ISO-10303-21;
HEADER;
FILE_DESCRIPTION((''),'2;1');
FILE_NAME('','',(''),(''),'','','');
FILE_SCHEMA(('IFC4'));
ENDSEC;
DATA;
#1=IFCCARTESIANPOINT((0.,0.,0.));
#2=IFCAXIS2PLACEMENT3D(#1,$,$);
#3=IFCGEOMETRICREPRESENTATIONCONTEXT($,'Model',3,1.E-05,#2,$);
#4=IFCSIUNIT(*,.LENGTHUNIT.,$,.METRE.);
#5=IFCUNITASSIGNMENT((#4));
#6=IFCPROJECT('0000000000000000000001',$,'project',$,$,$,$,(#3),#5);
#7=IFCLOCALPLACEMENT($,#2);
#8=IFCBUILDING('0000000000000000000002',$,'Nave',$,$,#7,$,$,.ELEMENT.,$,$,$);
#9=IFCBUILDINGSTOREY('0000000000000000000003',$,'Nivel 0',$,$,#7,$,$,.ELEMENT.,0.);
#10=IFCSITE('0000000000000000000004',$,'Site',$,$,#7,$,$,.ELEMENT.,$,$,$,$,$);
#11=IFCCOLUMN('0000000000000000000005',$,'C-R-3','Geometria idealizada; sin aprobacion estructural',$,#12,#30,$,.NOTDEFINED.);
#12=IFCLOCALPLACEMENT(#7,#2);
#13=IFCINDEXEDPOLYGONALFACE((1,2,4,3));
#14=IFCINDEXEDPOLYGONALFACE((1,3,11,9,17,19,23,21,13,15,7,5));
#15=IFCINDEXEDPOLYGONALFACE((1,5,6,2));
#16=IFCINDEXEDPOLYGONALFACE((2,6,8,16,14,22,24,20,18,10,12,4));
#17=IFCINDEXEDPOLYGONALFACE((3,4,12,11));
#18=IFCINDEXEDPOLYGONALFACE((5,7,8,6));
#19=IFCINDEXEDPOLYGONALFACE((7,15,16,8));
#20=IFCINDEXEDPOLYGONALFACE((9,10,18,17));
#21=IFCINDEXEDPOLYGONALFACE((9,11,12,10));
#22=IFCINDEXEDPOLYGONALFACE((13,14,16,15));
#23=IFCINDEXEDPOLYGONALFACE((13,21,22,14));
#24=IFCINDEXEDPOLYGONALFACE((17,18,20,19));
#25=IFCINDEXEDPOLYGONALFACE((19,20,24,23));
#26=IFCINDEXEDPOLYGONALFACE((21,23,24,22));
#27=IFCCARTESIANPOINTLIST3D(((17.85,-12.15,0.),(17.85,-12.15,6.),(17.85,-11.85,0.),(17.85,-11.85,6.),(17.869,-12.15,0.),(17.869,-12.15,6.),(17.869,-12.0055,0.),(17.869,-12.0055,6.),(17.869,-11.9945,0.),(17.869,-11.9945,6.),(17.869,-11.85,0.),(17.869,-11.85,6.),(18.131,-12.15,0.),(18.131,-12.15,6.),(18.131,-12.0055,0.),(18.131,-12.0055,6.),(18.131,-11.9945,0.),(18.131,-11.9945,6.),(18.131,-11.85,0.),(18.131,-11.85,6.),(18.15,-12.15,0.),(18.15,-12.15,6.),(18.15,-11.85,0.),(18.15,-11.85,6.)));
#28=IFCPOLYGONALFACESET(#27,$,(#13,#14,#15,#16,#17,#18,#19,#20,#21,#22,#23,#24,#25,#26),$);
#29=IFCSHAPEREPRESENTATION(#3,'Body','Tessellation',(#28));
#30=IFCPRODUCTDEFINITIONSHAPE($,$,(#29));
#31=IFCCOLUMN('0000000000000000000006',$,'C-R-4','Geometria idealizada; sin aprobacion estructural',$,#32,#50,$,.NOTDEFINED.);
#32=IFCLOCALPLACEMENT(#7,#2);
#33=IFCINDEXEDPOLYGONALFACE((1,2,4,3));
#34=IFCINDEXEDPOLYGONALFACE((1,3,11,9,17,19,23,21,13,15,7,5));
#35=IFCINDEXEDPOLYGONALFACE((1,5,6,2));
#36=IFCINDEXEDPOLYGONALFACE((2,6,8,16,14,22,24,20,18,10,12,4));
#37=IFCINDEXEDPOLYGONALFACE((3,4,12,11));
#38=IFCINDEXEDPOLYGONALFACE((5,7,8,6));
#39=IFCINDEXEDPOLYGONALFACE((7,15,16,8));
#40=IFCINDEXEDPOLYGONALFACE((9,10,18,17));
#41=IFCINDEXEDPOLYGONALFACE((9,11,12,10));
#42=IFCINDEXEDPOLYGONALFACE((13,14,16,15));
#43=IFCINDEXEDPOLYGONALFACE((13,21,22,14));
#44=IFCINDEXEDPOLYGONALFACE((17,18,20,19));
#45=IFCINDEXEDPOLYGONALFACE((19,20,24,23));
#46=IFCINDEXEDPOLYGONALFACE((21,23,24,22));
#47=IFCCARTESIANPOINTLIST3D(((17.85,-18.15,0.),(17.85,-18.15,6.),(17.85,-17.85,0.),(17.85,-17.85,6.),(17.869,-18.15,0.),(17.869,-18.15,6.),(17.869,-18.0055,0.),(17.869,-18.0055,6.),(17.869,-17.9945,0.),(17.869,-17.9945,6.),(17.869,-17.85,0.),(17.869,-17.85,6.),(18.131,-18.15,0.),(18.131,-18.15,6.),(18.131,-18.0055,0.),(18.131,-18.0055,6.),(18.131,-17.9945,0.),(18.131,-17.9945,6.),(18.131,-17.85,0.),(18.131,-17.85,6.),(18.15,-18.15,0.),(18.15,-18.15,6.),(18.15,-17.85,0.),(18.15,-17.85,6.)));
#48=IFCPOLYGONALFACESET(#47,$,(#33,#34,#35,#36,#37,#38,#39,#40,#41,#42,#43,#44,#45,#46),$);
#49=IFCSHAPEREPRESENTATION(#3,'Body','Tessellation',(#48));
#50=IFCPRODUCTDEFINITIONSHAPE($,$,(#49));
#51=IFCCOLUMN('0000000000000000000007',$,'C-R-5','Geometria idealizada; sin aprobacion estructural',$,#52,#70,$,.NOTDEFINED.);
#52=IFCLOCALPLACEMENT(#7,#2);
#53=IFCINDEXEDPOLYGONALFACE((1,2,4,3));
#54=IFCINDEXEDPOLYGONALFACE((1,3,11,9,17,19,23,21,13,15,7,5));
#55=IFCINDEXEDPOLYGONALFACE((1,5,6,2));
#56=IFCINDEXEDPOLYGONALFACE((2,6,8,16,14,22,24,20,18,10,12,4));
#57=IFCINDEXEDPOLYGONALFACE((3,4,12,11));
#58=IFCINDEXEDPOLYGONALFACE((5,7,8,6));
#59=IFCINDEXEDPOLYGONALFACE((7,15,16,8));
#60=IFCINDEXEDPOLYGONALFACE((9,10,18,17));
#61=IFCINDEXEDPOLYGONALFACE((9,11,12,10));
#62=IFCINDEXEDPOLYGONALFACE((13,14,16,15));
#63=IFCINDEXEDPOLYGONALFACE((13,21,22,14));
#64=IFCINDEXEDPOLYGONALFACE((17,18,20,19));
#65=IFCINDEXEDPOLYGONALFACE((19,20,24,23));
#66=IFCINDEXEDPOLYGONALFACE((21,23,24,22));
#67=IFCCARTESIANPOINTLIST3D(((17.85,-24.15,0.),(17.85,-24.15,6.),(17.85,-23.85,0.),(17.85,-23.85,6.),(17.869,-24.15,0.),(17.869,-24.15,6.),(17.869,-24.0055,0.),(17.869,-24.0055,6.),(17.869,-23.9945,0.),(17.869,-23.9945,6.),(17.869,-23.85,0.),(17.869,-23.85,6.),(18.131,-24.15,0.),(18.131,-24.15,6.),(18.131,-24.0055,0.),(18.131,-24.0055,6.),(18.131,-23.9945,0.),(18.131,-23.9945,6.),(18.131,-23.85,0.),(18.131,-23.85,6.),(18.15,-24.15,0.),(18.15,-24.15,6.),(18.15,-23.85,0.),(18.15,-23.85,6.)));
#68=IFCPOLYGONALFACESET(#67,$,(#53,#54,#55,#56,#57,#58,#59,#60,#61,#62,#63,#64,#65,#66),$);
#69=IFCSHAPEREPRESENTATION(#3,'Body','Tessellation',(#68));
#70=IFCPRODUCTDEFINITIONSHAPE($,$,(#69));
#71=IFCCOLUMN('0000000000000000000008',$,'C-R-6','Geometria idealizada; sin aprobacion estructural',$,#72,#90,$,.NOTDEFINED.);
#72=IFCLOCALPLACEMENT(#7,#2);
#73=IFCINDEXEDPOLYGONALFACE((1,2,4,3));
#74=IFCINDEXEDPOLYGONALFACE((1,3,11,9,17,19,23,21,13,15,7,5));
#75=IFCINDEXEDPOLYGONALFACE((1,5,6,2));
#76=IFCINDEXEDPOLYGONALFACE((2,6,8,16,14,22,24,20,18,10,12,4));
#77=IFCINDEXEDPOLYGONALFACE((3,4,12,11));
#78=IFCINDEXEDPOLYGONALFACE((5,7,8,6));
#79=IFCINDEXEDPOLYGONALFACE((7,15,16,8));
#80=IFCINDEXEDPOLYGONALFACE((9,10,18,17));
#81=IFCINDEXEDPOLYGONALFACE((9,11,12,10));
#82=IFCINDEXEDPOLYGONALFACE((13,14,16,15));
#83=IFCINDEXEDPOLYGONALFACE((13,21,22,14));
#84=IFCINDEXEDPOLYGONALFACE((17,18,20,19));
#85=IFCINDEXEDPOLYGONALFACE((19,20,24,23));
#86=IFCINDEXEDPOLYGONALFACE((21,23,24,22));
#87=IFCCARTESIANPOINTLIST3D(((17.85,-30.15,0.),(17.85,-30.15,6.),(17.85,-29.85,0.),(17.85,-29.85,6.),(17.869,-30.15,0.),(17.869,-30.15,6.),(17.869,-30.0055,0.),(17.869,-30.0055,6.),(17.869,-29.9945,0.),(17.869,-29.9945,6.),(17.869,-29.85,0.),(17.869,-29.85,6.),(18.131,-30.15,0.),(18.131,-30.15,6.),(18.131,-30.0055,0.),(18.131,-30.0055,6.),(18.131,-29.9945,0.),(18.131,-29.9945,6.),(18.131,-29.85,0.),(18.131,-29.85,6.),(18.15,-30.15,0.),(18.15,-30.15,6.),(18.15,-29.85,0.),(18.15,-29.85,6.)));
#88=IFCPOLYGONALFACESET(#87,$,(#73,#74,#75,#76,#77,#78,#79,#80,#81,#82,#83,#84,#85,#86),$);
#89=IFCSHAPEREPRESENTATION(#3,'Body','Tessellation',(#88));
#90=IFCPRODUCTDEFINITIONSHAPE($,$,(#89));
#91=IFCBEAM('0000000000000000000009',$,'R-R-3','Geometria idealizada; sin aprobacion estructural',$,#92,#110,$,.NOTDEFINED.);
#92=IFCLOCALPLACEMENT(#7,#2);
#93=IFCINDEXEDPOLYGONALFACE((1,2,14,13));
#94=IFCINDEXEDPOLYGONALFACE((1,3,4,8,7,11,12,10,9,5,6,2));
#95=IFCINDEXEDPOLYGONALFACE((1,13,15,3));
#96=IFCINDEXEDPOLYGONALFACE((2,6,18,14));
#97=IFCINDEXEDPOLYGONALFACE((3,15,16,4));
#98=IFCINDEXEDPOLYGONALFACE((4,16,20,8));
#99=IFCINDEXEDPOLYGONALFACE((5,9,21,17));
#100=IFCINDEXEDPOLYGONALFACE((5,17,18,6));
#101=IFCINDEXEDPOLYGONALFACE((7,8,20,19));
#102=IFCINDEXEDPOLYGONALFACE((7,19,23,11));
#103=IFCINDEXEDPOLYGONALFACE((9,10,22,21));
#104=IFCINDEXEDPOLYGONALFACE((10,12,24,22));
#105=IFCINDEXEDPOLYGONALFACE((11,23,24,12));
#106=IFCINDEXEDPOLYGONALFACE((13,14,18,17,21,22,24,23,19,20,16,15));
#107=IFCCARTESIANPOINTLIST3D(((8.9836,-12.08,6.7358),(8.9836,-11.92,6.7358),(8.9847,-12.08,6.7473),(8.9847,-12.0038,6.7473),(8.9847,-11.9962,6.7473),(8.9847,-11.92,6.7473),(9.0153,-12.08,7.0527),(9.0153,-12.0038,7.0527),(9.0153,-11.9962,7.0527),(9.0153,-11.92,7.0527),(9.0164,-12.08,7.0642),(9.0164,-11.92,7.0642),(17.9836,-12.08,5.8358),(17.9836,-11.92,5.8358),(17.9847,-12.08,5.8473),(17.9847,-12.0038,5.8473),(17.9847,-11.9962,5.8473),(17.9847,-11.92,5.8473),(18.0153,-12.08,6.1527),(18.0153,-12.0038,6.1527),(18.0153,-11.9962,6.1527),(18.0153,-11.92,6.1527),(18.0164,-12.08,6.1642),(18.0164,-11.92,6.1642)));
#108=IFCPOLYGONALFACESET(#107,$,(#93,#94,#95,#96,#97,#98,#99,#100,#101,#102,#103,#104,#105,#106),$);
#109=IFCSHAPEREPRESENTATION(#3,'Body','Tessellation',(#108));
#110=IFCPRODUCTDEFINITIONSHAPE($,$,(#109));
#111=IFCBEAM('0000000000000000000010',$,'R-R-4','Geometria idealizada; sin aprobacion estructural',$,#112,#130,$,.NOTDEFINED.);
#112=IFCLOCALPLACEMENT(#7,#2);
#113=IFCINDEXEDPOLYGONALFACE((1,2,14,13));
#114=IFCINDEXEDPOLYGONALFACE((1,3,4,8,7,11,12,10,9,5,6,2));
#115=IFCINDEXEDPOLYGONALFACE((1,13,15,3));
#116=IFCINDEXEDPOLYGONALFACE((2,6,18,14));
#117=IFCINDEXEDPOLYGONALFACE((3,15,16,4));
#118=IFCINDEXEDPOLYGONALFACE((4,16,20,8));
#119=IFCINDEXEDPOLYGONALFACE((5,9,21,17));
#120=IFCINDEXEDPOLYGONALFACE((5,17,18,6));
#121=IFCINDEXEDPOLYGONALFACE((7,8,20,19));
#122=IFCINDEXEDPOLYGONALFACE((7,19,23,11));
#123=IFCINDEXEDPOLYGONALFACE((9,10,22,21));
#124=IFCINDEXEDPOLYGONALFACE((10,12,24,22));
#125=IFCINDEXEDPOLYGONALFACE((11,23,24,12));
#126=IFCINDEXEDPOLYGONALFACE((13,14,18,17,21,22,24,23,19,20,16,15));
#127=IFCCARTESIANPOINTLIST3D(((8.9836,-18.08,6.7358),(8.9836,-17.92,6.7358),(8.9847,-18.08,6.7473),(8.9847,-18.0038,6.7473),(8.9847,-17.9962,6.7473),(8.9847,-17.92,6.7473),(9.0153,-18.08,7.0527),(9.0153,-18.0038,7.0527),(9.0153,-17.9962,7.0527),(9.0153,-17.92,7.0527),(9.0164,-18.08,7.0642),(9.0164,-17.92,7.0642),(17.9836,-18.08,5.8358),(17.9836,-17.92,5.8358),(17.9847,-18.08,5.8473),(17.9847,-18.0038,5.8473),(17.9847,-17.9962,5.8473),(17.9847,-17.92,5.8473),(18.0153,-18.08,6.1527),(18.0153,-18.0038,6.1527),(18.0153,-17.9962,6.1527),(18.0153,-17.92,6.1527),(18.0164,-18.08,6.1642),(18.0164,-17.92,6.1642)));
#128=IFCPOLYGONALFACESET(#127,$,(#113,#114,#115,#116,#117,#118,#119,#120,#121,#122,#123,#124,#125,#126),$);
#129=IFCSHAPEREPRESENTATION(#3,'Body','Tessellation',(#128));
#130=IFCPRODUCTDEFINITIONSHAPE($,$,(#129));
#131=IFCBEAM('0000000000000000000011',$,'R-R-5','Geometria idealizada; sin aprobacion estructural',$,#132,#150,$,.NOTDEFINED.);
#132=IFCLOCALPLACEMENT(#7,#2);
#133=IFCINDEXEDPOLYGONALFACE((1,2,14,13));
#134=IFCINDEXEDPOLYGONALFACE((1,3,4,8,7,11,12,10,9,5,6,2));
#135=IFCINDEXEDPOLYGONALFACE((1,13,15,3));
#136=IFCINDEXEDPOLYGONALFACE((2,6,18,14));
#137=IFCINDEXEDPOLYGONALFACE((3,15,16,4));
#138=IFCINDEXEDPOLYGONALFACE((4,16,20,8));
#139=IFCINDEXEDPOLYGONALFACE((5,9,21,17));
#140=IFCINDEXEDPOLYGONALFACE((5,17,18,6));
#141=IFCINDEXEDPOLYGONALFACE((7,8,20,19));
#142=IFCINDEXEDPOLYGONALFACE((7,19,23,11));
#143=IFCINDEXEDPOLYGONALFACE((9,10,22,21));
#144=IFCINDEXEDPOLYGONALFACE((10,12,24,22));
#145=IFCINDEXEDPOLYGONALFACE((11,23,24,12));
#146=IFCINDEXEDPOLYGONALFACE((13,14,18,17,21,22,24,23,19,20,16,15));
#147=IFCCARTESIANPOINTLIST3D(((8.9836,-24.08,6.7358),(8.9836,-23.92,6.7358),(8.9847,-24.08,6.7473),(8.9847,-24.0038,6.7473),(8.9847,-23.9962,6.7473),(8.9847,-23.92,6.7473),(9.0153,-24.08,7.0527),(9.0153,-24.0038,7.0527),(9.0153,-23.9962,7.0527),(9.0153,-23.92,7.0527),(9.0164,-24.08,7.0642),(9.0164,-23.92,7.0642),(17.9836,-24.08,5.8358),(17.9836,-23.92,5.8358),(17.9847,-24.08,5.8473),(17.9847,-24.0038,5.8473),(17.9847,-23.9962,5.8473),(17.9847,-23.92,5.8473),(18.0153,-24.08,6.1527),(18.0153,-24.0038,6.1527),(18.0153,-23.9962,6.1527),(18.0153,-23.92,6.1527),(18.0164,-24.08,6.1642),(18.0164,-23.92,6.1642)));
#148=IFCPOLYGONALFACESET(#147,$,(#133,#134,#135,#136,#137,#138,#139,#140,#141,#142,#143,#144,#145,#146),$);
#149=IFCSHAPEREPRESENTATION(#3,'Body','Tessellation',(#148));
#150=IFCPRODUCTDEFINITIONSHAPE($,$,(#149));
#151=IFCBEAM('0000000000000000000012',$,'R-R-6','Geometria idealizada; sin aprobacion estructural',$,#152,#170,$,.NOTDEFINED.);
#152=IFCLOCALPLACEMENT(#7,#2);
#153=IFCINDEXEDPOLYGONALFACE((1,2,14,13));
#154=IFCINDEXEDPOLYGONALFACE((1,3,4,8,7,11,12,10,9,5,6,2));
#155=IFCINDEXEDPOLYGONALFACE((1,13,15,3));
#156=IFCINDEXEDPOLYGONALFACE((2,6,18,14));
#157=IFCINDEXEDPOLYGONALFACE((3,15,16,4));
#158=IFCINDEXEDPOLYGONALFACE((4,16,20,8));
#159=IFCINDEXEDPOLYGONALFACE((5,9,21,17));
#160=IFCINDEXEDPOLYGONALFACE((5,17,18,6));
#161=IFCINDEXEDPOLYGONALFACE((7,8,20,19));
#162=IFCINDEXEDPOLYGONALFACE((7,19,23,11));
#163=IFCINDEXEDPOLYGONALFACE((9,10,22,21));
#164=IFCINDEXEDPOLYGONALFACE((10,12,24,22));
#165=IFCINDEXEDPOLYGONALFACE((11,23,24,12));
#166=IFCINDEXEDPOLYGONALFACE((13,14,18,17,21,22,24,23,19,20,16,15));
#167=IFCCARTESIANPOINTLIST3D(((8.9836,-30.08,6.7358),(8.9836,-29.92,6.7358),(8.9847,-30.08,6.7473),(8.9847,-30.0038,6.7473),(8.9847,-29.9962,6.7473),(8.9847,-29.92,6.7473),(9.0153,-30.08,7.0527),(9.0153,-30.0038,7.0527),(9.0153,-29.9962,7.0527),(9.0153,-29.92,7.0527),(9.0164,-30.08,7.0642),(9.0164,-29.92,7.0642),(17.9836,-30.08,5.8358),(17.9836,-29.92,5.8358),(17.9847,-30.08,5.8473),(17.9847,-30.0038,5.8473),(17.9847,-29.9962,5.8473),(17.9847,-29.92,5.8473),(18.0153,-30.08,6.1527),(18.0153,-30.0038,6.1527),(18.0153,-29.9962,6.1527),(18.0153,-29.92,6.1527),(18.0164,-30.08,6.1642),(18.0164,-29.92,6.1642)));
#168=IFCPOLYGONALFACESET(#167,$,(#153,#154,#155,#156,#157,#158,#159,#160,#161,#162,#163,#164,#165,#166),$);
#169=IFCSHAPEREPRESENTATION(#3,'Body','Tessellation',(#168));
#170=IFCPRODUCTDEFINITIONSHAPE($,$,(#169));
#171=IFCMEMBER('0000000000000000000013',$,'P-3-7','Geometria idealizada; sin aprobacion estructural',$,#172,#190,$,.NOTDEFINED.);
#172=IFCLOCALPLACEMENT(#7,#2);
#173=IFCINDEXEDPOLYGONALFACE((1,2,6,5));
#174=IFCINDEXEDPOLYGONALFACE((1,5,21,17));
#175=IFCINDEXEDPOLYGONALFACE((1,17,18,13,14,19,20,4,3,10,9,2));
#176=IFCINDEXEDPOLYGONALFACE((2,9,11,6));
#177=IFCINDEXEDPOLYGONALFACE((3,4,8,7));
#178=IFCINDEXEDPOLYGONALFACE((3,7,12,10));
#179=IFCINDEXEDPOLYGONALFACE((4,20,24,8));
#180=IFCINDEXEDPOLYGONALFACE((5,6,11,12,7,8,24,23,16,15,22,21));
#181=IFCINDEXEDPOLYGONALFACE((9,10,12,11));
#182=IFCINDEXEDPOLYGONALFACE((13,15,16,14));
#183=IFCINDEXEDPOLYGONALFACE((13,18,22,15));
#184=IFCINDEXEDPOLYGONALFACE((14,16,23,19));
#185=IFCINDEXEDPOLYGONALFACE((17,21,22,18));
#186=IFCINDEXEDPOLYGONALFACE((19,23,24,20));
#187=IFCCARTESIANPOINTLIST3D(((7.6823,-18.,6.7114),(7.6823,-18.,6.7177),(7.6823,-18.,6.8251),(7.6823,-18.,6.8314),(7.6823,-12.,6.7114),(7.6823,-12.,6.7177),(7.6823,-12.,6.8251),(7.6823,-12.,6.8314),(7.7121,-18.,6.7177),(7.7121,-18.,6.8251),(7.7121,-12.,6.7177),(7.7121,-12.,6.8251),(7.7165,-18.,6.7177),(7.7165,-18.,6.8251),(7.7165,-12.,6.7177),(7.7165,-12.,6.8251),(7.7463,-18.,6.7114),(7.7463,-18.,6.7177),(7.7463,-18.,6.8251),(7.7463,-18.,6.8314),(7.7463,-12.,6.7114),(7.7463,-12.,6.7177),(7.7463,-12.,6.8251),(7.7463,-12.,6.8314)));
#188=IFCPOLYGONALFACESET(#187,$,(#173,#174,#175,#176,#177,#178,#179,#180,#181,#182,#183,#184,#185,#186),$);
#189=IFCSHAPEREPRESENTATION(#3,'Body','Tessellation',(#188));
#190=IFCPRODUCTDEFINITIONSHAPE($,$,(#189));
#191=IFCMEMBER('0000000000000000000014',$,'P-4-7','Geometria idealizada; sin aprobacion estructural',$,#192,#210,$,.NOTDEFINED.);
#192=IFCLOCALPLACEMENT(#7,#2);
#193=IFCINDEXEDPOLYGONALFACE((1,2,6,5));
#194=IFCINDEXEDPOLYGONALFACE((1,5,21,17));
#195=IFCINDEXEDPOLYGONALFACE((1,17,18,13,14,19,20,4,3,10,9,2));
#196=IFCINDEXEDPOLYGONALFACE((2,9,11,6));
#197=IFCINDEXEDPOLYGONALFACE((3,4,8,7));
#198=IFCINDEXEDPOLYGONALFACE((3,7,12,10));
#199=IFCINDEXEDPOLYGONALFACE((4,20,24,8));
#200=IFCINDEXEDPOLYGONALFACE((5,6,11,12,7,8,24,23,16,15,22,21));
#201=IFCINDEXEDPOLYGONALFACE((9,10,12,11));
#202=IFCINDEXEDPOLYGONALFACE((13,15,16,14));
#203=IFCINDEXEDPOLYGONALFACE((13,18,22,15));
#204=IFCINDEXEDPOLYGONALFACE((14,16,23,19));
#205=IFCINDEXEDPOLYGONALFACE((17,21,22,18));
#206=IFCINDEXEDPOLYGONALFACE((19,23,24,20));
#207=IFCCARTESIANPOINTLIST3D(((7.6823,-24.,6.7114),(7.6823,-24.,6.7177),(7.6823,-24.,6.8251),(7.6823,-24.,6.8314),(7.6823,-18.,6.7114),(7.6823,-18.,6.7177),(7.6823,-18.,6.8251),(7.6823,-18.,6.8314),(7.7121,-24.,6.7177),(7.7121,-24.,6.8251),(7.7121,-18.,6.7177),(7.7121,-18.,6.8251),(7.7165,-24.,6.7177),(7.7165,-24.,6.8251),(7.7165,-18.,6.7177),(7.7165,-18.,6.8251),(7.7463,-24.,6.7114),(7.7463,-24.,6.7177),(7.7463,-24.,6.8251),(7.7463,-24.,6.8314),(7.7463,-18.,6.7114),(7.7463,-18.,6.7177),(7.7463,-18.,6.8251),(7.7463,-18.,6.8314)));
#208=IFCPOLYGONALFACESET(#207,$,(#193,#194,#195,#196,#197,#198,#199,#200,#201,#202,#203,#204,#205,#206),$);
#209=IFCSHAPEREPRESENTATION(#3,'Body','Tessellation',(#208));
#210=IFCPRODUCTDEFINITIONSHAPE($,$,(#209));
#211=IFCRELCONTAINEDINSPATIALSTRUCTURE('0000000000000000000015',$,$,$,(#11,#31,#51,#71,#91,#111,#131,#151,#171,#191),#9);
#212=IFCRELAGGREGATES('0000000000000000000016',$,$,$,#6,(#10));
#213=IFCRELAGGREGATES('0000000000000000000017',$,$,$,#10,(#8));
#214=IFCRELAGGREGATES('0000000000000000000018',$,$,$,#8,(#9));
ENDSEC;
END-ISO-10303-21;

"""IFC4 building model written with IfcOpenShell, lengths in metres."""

from ifc_helpers import new_model, si_unit, frame, origin, place, context, project, spatial, polyline, outline, extrude, element, save


model = new_model("IFC4")

# Units and contexts
model_context = context("Model", 3, precision=1e-05, world=origin())
ifc_project = project(units=[si_unit("LENGTHUNIT", "METRE")], contexts=[model_context])

# Site, building, storey
placement = place(None, origin())
site = spatial("IfcSite", under=ifc_project, at=placement, Name="Site", CompositionType="ELEMENT")
building = spatial("IfcBuilding", under=site, at=placement, Name="Nave", CompositionType="ELEMENT")
storey = spatial("IfcBuildingStorey", under=building, at=placement, Name="Nivel 0", CompositionType="ELEMENT", Elevation=0.0)

# Columns
for number, where, z_axis, x_axis, name in (
    (1, (18.0, -12.0, 0.0), (0.0, 0.0, 1.0), (0.0, -1.0, 0.0), "C-R-3"),
    (2, (18.0, -18.0, 0.0), (0.0, 0.0, 1.0), (0.0, -1.0, 0.0), "C-R-4"),
    (3, (18.0, -24.0, 0.0), (0.0, 0.0, 1.0), (0.0, -1.0, 0.0), "C-R-5"),
    (4, (18.0, -30.0, 0.0), (0.0, 0.0, 1.0), (0.0, -1.0, 0.0), "C-R-6"),
):
    element("IfcColumn", number, at=place(placement, frame(where, z_axis=z_axis, x_axis=x_axis)), inside=storey, Name=name, Description="Geometria idealizada; sin aprobacion estructural", PredefinedType="NOTDEFINED", context=model_context, shape_type="SweptSolid", body=[
        extrude(outline(polyline([(-0.15, -0.15), (0.15, -0.15), (0.15, -0.131), (0.0055, -0.131), (0.0055, 0.131), (0.15, 0.131), (0.15, 0.15), (-0.15, 0.15), (-0.15, 0.131), (-0.0055, 0.131), (-0.0055, -0.131), (-0.15, -0.131), (-0.15, -0.15)])), origin(), (0.0, 0.0, 1.0), 6.0),
    ])

# Beams
for number, where, z_axis, x_axis, name in (
    (5, (9.0, -12.0, 6.9), (0.995037, 0.0, -0.099504), (0.0, 1.0, 0.0), "R-R-3"),
    (6, (9.0, -18.0, 6.9), (0.995037, 0.0, -0.099504), (0.0, 1.0, 0.0), "R-R-4"),
    (7, (9.0, -24.0, 6.9), (0.995037, 0.0, -0.099504), (0.0, 1.0, 0.0), "R-R-5"),
    (8, (9.0, -30.0, 6.9), (0.995037, 0.0, -0.099504), (0.0, 1.0, 0.0), "R-R-6"),
):
    element("IfcBeam", number, at=place(placement, frame(where, z_axis=z_axis, x_axis=x_axis)), inside=storey, Name=name, Description="Geometria idealizada; sin aprobacion estructural", PredefinedType="NOTDEFINED", context=model_context, shape_type="SweptSolid", body=[
        extrude(outline(polyline([(-0.08, -0.165), (0.08, -0.165), (0.08, -0.1535), (0.0037, -0.1535), (0.0037, 0.1535), (0.08, 0.1535), (0.08, 0.165), (-0.08, 0.165), (-0.08, 0.1535), (-0.0037, 0.1535), (-0.0037, -0.1535), (-0.08, -0.1535), (-0.08, -0.165)])), origin(), (0.0, 0.0, 1.0), 9.0449),
    ])

# Members
for number, where, z_axis, x_axis, name in (
    (9, (7.7143, -12.0, 6.7714), (0.0, -1.0, 0.0), (1.0, 0.0, 0.0), "P-3-7"),
    (10, (7.7143, -18.0, 6.7714), (0.0, -1.0, 0.0), (1.0, 0.0, 0.0), "P-4-7"),
):
    element("IfcMember", number, at=place(placement, frame(where, z_axis=z_axis, x_axis=x_axis)), inside=storey, Name=name, Description="Geometria idealizada; sin aprobacion estructural", PredefinedType="NOTDEFINED", context=model_context, shape_type="SweptSolid", body=[
        extrude(outline(polyline([(-0.032, -0.06), (0.032, -0.06), (0.032, -0.0537), (0.0022, -0.0537), (0.0022, 0.0537), (0.032, 0.0537), (0.032, 0.06), (-0.032, 0.06), (-0.032, 0.0537), (-0.0022, 0.0537), (-0.0022, -0.0537), (-0.032, -0.0537), (-0.032, -0.06)])), origin(), (0.0, 0.0, 1.0), 6.0),
    ])

save(model, "model.ifc")
